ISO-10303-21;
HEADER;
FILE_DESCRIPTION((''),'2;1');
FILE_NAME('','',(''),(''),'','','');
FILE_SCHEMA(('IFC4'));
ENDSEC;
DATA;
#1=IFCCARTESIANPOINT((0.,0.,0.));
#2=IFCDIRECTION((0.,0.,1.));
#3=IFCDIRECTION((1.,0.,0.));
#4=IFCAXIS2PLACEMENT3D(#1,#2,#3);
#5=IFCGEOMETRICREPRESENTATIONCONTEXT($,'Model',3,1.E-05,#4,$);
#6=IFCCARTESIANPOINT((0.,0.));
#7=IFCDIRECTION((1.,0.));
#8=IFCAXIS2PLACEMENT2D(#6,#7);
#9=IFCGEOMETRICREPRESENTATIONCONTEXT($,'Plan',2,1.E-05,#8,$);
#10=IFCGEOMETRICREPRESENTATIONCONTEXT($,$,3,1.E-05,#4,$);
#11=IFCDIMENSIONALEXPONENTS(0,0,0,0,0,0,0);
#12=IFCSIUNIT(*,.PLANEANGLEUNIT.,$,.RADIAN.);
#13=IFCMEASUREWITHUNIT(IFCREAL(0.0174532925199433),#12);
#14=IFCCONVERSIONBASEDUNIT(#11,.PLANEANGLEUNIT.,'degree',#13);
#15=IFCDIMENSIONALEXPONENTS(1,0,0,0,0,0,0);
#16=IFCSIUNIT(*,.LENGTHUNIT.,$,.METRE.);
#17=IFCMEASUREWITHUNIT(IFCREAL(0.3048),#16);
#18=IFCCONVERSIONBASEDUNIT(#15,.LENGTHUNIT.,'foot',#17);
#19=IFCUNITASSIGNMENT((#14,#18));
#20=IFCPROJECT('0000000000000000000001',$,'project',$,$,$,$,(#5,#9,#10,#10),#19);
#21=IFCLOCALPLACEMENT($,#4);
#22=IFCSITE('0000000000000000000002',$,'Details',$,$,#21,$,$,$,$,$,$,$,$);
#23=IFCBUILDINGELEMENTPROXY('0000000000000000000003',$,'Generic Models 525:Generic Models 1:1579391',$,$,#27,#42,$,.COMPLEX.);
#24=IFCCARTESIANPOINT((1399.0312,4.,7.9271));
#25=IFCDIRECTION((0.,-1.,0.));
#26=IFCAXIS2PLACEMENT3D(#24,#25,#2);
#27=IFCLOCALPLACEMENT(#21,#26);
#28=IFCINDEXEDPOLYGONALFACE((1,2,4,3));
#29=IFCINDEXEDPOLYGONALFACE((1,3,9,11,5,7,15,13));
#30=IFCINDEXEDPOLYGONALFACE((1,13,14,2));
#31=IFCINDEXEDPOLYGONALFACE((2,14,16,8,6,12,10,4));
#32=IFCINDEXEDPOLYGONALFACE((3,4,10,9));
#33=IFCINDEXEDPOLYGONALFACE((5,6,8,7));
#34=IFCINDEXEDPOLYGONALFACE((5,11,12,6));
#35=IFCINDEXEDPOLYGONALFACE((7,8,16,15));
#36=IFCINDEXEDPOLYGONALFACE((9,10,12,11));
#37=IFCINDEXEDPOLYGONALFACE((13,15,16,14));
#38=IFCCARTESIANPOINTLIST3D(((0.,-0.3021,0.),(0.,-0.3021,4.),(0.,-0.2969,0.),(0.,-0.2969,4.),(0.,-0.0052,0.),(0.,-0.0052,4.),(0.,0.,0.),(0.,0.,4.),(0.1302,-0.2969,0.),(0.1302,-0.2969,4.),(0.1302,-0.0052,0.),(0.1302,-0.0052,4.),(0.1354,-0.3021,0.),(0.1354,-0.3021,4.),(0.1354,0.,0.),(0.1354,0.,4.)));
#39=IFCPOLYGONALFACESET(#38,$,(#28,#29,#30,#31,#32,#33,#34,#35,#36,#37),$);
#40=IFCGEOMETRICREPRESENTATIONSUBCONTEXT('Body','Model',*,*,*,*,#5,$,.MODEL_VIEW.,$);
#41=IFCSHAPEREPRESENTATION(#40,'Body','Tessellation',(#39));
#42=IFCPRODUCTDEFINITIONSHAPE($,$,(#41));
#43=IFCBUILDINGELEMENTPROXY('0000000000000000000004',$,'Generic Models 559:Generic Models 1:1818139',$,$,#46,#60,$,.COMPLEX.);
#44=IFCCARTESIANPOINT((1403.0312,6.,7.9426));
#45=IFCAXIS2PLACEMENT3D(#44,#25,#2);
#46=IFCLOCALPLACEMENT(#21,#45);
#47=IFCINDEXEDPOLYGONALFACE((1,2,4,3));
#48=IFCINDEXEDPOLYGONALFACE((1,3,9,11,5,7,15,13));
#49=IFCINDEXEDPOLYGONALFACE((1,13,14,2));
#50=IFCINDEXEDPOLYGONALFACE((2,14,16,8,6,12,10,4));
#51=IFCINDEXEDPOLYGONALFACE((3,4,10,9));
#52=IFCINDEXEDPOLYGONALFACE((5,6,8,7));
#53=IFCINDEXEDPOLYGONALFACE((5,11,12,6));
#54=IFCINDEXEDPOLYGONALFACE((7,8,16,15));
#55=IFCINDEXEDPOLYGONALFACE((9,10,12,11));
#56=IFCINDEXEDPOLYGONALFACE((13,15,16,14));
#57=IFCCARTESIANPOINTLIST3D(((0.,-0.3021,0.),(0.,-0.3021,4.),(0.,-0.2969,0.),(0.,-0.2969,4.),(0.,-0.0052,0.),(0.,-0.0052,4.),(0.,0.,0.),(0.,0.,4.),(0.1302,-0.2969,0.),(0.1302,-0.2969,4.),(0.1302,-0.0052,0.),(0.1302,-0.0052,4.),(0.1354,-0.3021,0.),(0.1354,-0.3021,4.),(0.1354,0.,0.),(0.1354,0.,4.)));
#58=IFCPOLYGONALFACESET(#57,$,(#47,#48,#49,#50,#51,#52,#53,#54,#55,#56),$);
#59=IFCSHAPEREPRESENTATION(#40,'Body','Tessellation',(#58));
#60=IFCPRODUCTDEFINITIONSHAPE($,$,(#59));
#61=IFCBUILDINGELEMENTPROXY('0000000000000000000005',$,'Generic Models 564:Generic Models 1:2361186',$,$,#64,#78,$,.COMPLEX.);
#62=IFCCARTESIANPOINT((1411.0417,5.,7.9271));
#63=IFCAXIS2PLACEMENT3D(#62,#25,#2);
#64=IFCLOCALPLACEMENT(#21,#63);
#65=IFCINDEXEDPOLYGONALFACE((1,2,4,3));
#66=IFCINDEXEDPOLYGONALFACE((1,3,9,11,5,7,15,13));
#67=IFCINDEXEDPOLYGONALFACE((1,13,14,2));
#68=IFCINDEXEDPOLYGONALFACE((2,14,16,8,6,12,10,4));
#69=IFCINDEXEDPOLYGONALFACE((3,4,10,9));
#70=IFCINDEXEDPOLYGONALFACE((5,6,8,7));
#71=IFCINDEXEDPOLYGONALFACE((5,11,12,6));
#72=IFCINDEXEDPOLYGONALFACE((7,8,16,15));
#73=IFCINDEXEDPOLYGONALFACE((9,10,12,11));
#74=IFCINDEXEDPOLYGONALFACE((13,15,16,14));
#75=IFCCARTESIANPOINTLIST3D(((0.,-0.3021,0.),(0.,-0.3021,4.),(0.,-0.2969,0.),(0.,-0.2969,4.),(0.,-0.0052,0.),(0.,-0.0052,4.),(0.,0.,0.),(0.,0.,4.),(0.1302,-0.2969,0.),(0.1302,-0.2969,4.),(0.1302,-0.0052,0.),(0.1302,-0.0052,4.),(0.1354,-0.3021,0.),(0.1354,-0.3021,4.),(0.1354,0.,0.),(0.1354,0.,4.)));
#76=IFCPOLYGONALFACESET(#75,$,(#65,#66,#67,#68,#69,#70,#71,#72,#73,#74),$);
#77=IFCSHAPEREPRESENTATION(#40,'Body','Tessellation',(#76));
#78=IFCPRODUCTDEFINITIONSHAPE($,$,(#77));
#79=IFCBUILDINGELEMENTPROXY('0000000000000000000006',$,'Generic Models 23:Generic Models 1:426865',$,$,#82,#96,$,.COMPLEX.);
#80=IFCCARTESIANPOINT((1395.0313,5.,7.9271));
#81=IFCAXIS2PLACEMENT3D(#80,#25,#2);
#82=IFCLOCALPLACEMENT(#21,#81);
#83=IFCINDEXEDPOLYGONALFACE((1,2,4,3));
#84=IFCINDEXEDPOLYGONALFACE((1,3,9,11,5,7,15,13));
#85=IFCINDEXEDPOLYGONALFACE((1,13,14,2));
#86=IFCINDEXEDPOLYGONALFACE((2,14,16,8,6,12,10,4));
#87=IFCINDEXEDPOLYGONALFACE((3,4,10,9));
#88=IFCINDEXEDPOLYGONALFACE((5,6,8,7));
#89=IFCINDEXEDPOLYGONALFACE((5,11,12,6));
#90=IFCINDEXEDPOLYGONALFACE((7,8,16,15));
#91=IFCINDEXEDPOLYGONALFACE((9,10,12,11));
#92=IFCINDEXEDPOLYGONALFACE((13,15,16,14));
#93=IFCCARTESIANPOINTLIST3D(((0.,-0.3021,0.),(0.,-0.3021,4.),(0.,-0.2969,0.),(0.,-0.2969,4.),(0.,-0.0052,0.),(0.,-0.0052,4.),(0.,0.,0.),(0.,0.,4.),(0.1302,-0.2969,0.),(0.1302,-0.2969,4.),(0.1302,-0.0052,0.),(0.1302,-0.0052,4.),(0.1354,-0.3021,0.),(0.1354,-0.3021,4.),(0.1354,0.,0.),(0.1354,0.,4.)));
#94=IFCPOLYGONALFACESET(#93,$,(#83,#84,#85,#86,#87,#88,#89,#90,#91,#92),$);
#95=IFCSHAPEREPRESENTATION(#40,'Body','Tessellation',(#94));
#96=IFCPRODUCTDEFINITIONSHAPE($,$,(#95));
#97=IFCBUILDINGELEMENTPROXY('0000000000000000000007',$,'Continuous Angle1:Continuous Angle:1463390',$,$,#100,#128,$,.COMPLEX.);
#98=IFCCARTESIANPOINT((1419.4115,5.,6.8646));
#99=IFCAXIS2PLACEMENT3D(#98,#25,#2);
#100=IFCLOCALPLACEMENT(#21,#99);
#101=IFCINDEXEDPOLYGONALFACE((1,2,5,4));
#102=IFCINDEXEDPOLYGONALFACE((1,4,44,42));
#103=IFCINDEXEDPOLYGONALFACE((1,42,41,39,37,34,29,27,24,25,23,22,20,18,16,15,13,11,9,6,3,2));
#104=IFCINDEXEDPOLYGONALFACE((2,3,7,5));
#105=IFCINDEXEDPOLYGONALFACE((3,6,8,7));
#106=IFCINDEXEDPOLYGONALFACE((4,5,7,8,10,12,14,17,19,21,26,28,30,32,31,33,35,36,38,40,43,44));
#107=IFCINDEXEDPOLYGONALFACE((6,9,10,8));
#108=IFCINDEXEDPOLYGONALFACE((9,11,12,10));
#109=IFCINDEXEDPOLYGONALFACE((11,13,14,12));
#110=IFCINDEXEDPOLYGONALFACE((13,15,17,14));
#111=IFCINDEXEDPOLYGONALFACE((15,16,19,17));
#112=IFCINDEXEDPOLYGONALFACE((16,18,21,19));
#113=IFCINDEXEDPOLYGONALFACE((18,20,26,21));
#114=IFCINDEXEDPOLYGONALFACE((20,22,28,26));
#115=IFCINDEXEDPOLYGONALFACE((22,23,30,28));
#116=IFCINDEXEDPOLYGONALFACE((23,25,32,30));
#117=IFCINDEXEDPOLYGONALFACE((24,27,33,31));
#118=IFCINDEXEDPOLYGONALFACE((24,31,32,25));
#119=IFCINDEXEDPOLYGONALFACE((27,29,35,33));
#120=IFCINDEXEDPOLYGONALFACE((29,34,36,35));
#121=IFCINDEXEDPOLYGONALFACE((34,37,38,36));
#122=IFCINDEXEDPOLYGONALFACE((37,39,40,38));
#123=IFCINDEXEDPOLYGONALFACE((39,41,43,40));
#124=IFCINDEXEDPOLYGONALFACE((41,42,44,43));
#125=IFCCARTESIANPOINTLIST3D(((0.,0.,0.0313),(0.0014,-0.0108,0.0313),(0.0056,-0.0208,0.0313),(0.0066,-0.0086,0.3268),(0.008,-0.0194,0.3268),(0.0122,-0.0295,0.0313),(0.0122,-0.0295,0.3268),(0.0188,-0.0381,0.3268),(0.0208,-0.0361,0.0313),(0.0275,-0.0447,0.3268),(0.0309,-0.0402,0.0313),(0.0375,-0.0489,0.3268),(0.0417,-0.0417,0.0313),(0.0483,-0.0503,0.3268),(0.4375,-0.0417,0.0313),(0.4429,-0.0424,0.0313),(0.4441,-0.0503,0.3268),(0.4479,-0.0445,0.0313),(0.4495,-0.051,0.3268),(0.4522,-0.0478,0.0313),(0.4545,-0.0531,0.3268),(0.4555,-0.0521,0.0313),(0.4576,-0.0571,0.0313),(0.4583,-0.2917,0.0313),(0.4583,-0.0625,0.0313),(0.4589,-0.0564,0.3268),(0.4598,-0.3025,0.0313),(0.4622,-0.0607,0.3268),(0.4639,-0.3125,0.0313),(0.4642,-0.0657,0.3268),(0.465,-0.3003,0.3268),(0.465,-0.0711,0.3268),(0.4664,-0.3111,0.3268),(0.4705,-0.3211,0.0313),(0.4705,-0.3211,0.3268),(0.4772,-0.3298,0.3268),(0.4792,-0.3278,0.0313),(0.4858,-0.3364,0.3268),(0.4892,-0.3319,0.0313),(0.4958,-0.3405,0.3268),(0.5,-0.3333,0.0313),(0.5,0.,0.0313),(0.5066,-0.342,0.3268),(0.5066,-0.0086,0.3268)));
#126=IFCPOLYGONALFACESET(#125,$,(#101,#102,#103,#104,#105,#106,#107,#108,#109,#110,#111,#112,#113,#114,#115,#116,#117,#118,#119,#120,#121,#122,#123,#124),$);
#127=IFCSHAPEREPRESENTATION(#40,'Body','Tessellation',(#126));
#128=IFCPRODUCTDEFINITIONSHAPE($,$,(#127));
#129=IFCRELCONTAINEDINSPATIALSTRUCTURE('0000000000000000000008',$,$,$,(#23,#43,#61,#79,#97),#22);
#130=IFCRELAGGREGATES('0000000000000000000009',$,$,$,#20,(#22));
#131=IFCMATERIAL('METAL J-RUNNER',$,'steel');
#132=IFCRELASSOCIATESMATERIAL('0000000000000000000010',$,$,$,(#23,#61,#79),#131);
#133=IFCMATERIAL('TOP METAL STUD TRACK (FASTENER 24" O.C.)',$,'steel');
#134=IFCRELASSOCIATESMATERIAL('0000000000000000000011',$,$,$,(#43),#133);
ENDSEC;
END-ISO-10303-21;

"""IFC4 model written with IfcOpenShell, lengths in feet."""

from ifc_helpers import new_model, entity, si_unit, converted_unit, frame, origin_with_axes, origin_2d_with_axis, place, context, subcontext, project, spatial, polyline, line, indexed_curve, outline, extrude, material, element, save


model = new_model("IFC4")

# Units and contexts
model_context = context("Model", 3, precision=1e-05, world=origin_with_axes())
plan_context = context("Plan", 2, precision=1e-05, world=origin_2d_with_axis())
context_of_model = context(None, 3, precision=1e-05, world=origin_with_axes())
body_context = subcontext(model_context, "Body", "Model", "MODEL_VIEW")
ifc_project = project(units=[converted_unit("PLANEANGLEUNIT", "degree", entity("IfcReal", 0.0174532925199433), si_unit("PLANEANGLEUNIT", "RADIAN"), dimensions=[0, 0, 0, 0, 0, 0, 0]), converted_unit("LENGTHUNIT", "foot", entity("IfcReal", 0.3048), si_unit("LENGTHUNIT", "METRE"), dimensions=[1, 0, 0, 0, 0, 0, 0])], contexts=[model_context, plan_context, context_of_model, context_of_model])

# Site
site_placement = place(None, origin_with_axes())
site = spatial("IfcSite", under=ifc_project, at=site_placement, Name="Details")

# Building element proxies
ifc_material_1 = material(Name="METAL J-RUNNER", Category="steel")
proxy_1_placement = place(site_placement, frame((1399.0312, 4.0, 7.9271), z_axis=(0.0, -1.0, 0.0), x_axis=(0.0, 0.0, 1.0)))
element("IfcBuildingElementProxy", 1, at=proxy_1_placement, inside=site, material=ifc_material_1, Name="Generic Models 525:Generic Models 1:1579391", PredefinedType="COMPLEX", context=body_context, shape_type="SweptSolid", body=[
    extrude(outline(polyline([(-0.151, -0.069), (0.151, -0.069), (0.151, 0.0664), (0.1458, 0.0664), (0.1458, -0.0638), (-0.1458, -0.0638), (-0.1458, 0.0664), (-0.151, 0.0664), (-0.151, -0.069)])), frame((0.0664, -0.151, 0.0), z_axis=(0.0, 0.0, -1.0), x_axis=(0.0, -1.0, 0.0)), (0.0, 0.0, -1.0), 4.0),
])
ifc_material_2 = material(Name="TOP METAL STUD TRACK (FASTENER 24\" O.C.)", Category="steel")
proxy_2_placement = place(site_placement, frame((1403.0312, 6.0, 7.9426), z_axis=(0.0, -1.0, 0.0), x_axis=(0.0, 0.0, 1.0)))
element("IfcBuildingElementProxy", 2, at=proxy_2_placement, inside=site, material=ifc_material_2, Name="Generic Models 559:Generic Models 1:1818139", PredefinedType="COMPLEX", context=body_context, shape_type="SweptSolid", body=[
    extrude(outline(indexed_curve([(-0.069, -0.151), (0.0664, -0.151), (0.0664, -0.1458), (-0.0638, -0.1458), (-0.0638, 0.1458), (0.0664, 0.1458), (0.0664, 0.151), (-0.069, 0.151)], segments=[line(5, 6), line(6, 7), line(7, 8), line(8, 1), line(1, 2), line(2, 3), line(3, 4), line(4, 5)], self_intersect=False)), frame((0.0664, -0.151, 0.0), z_axis=(0.0, 0.0, -1.0), x_axis=(-1.0, 0.0, 0.0)), (0.0, 0.0, -1.0), 4.0),
])
proxy_3_placement = place(site_placement, frame((1411.0417, 5.0, 7.9271), z_axis=(0.0, -1.0, 0.0), x_axis=(0.0, 0.0, 1.0)))
element("IfcBuildingElementProxy", 3, at=proxy_3_placement, inside=site, material=ifc_material_1, Name="Generic Models 564:Generic Models 1:2361186", PredefinedType="COMPLEX", context=body_context, shape_type="SweptSolid", body=[
    extrude(outline(polyline([(-0.069, -0.151), (0.0664, -0.151), (0.0664, -0.1458), (-0.0638, -0.1458), (-0.0638, 0.1458), (0.0664, 0.1458), (0.0664, 0.151), (-0.069, 0.151), (-0.069, -0.151)])), frame((0.0664, -0.151, 0.0), z_axis=(0.0, 0.0, -1.0), x_axis=(-1.0, 0.0, 0.0)), (0.0, 0.0, -1.0), 4.0),
])
proxy_4_placement = place(site_placement, frame((1395.0313, 5.0, 7.9271), z_axis=(0.0, -1.0, 0.0), x_axis=(0.0, 0.0, 1.0)))
element("IfcBuildingElementProxy", 4, at=proxy_4_placement, inside=site, material=ifc_material_1, Name="Generic Models 23:Generic Models 1:426865", PredefinedType="COMPLEX", context=body_context, shape_type="SweptSolid", body=[
    extrude(outline(polyline([(-0.0638, 0.1458), (0.0664, 0.1458), (0.0664, 0.151), (-0.069, 0.151), (-0.069, -0.151), (0.0664, -0.151), (0.0664, -0.1458), (-0.0638, -0.1458), (-0.0638, 0.1458)])), frame((0.0664, -0.151, 0.0), z_axis=(0.0, 0.0, -1.0), x_axis=(-1.0, 0.0, 0.0)), (0.0, 0.0, -1.0), 4.0),
])
proxy_5_placement = place(site_placement, frame((1419.4115, 5.0, 6.8646), z_axis=(0.0, -1.0, 0.0), x_axis=(0.0, 0.0, 1.0)))
element("IfcBuildingElementProxy", 5, at=proxy_5_placement, inside=site, Name="Continuous Angle1:Continuous Angle:1463390", PredefinedType="COMPLEX", context=body_context, shape_type="SweptSolid", body=[
    extrude(outline(polyline([(0.2352, 0.0), (0.2247, -0.0027), (0.2152, -0.0081), (0.0324, -0.1463), (0.0277, -0.149), (0.0224, -0.1504), (0.017, -0.1503), (0.0117, -0.1489), (0.007, -0.1461), (0.0032, -0.1423), (-0.2355, 0.1735), (-0.2431, 0.1812), (-0.2525, 0.1867), (-0.263, 0.1896), (-0.2739, 0.1897), (-0.2844, 0.1869), (-0.2939, 0.1816), (0.0077, -0.2173), (0.2736, -0.0162), (0.2659, -0.0085), (0.2566, -0.003), (0.2461, -0.0001), (0.2352, 0.0)])), frame((0.3221, -0.1249, 0.0313), z_axis=(0.0, 0.0, -1.0), x_axis=(0.60311, -0.797658, 0.0)), (0.036779, -0.000261, -0.999323), 0.2957),
])

save(model, "model.ifc")
